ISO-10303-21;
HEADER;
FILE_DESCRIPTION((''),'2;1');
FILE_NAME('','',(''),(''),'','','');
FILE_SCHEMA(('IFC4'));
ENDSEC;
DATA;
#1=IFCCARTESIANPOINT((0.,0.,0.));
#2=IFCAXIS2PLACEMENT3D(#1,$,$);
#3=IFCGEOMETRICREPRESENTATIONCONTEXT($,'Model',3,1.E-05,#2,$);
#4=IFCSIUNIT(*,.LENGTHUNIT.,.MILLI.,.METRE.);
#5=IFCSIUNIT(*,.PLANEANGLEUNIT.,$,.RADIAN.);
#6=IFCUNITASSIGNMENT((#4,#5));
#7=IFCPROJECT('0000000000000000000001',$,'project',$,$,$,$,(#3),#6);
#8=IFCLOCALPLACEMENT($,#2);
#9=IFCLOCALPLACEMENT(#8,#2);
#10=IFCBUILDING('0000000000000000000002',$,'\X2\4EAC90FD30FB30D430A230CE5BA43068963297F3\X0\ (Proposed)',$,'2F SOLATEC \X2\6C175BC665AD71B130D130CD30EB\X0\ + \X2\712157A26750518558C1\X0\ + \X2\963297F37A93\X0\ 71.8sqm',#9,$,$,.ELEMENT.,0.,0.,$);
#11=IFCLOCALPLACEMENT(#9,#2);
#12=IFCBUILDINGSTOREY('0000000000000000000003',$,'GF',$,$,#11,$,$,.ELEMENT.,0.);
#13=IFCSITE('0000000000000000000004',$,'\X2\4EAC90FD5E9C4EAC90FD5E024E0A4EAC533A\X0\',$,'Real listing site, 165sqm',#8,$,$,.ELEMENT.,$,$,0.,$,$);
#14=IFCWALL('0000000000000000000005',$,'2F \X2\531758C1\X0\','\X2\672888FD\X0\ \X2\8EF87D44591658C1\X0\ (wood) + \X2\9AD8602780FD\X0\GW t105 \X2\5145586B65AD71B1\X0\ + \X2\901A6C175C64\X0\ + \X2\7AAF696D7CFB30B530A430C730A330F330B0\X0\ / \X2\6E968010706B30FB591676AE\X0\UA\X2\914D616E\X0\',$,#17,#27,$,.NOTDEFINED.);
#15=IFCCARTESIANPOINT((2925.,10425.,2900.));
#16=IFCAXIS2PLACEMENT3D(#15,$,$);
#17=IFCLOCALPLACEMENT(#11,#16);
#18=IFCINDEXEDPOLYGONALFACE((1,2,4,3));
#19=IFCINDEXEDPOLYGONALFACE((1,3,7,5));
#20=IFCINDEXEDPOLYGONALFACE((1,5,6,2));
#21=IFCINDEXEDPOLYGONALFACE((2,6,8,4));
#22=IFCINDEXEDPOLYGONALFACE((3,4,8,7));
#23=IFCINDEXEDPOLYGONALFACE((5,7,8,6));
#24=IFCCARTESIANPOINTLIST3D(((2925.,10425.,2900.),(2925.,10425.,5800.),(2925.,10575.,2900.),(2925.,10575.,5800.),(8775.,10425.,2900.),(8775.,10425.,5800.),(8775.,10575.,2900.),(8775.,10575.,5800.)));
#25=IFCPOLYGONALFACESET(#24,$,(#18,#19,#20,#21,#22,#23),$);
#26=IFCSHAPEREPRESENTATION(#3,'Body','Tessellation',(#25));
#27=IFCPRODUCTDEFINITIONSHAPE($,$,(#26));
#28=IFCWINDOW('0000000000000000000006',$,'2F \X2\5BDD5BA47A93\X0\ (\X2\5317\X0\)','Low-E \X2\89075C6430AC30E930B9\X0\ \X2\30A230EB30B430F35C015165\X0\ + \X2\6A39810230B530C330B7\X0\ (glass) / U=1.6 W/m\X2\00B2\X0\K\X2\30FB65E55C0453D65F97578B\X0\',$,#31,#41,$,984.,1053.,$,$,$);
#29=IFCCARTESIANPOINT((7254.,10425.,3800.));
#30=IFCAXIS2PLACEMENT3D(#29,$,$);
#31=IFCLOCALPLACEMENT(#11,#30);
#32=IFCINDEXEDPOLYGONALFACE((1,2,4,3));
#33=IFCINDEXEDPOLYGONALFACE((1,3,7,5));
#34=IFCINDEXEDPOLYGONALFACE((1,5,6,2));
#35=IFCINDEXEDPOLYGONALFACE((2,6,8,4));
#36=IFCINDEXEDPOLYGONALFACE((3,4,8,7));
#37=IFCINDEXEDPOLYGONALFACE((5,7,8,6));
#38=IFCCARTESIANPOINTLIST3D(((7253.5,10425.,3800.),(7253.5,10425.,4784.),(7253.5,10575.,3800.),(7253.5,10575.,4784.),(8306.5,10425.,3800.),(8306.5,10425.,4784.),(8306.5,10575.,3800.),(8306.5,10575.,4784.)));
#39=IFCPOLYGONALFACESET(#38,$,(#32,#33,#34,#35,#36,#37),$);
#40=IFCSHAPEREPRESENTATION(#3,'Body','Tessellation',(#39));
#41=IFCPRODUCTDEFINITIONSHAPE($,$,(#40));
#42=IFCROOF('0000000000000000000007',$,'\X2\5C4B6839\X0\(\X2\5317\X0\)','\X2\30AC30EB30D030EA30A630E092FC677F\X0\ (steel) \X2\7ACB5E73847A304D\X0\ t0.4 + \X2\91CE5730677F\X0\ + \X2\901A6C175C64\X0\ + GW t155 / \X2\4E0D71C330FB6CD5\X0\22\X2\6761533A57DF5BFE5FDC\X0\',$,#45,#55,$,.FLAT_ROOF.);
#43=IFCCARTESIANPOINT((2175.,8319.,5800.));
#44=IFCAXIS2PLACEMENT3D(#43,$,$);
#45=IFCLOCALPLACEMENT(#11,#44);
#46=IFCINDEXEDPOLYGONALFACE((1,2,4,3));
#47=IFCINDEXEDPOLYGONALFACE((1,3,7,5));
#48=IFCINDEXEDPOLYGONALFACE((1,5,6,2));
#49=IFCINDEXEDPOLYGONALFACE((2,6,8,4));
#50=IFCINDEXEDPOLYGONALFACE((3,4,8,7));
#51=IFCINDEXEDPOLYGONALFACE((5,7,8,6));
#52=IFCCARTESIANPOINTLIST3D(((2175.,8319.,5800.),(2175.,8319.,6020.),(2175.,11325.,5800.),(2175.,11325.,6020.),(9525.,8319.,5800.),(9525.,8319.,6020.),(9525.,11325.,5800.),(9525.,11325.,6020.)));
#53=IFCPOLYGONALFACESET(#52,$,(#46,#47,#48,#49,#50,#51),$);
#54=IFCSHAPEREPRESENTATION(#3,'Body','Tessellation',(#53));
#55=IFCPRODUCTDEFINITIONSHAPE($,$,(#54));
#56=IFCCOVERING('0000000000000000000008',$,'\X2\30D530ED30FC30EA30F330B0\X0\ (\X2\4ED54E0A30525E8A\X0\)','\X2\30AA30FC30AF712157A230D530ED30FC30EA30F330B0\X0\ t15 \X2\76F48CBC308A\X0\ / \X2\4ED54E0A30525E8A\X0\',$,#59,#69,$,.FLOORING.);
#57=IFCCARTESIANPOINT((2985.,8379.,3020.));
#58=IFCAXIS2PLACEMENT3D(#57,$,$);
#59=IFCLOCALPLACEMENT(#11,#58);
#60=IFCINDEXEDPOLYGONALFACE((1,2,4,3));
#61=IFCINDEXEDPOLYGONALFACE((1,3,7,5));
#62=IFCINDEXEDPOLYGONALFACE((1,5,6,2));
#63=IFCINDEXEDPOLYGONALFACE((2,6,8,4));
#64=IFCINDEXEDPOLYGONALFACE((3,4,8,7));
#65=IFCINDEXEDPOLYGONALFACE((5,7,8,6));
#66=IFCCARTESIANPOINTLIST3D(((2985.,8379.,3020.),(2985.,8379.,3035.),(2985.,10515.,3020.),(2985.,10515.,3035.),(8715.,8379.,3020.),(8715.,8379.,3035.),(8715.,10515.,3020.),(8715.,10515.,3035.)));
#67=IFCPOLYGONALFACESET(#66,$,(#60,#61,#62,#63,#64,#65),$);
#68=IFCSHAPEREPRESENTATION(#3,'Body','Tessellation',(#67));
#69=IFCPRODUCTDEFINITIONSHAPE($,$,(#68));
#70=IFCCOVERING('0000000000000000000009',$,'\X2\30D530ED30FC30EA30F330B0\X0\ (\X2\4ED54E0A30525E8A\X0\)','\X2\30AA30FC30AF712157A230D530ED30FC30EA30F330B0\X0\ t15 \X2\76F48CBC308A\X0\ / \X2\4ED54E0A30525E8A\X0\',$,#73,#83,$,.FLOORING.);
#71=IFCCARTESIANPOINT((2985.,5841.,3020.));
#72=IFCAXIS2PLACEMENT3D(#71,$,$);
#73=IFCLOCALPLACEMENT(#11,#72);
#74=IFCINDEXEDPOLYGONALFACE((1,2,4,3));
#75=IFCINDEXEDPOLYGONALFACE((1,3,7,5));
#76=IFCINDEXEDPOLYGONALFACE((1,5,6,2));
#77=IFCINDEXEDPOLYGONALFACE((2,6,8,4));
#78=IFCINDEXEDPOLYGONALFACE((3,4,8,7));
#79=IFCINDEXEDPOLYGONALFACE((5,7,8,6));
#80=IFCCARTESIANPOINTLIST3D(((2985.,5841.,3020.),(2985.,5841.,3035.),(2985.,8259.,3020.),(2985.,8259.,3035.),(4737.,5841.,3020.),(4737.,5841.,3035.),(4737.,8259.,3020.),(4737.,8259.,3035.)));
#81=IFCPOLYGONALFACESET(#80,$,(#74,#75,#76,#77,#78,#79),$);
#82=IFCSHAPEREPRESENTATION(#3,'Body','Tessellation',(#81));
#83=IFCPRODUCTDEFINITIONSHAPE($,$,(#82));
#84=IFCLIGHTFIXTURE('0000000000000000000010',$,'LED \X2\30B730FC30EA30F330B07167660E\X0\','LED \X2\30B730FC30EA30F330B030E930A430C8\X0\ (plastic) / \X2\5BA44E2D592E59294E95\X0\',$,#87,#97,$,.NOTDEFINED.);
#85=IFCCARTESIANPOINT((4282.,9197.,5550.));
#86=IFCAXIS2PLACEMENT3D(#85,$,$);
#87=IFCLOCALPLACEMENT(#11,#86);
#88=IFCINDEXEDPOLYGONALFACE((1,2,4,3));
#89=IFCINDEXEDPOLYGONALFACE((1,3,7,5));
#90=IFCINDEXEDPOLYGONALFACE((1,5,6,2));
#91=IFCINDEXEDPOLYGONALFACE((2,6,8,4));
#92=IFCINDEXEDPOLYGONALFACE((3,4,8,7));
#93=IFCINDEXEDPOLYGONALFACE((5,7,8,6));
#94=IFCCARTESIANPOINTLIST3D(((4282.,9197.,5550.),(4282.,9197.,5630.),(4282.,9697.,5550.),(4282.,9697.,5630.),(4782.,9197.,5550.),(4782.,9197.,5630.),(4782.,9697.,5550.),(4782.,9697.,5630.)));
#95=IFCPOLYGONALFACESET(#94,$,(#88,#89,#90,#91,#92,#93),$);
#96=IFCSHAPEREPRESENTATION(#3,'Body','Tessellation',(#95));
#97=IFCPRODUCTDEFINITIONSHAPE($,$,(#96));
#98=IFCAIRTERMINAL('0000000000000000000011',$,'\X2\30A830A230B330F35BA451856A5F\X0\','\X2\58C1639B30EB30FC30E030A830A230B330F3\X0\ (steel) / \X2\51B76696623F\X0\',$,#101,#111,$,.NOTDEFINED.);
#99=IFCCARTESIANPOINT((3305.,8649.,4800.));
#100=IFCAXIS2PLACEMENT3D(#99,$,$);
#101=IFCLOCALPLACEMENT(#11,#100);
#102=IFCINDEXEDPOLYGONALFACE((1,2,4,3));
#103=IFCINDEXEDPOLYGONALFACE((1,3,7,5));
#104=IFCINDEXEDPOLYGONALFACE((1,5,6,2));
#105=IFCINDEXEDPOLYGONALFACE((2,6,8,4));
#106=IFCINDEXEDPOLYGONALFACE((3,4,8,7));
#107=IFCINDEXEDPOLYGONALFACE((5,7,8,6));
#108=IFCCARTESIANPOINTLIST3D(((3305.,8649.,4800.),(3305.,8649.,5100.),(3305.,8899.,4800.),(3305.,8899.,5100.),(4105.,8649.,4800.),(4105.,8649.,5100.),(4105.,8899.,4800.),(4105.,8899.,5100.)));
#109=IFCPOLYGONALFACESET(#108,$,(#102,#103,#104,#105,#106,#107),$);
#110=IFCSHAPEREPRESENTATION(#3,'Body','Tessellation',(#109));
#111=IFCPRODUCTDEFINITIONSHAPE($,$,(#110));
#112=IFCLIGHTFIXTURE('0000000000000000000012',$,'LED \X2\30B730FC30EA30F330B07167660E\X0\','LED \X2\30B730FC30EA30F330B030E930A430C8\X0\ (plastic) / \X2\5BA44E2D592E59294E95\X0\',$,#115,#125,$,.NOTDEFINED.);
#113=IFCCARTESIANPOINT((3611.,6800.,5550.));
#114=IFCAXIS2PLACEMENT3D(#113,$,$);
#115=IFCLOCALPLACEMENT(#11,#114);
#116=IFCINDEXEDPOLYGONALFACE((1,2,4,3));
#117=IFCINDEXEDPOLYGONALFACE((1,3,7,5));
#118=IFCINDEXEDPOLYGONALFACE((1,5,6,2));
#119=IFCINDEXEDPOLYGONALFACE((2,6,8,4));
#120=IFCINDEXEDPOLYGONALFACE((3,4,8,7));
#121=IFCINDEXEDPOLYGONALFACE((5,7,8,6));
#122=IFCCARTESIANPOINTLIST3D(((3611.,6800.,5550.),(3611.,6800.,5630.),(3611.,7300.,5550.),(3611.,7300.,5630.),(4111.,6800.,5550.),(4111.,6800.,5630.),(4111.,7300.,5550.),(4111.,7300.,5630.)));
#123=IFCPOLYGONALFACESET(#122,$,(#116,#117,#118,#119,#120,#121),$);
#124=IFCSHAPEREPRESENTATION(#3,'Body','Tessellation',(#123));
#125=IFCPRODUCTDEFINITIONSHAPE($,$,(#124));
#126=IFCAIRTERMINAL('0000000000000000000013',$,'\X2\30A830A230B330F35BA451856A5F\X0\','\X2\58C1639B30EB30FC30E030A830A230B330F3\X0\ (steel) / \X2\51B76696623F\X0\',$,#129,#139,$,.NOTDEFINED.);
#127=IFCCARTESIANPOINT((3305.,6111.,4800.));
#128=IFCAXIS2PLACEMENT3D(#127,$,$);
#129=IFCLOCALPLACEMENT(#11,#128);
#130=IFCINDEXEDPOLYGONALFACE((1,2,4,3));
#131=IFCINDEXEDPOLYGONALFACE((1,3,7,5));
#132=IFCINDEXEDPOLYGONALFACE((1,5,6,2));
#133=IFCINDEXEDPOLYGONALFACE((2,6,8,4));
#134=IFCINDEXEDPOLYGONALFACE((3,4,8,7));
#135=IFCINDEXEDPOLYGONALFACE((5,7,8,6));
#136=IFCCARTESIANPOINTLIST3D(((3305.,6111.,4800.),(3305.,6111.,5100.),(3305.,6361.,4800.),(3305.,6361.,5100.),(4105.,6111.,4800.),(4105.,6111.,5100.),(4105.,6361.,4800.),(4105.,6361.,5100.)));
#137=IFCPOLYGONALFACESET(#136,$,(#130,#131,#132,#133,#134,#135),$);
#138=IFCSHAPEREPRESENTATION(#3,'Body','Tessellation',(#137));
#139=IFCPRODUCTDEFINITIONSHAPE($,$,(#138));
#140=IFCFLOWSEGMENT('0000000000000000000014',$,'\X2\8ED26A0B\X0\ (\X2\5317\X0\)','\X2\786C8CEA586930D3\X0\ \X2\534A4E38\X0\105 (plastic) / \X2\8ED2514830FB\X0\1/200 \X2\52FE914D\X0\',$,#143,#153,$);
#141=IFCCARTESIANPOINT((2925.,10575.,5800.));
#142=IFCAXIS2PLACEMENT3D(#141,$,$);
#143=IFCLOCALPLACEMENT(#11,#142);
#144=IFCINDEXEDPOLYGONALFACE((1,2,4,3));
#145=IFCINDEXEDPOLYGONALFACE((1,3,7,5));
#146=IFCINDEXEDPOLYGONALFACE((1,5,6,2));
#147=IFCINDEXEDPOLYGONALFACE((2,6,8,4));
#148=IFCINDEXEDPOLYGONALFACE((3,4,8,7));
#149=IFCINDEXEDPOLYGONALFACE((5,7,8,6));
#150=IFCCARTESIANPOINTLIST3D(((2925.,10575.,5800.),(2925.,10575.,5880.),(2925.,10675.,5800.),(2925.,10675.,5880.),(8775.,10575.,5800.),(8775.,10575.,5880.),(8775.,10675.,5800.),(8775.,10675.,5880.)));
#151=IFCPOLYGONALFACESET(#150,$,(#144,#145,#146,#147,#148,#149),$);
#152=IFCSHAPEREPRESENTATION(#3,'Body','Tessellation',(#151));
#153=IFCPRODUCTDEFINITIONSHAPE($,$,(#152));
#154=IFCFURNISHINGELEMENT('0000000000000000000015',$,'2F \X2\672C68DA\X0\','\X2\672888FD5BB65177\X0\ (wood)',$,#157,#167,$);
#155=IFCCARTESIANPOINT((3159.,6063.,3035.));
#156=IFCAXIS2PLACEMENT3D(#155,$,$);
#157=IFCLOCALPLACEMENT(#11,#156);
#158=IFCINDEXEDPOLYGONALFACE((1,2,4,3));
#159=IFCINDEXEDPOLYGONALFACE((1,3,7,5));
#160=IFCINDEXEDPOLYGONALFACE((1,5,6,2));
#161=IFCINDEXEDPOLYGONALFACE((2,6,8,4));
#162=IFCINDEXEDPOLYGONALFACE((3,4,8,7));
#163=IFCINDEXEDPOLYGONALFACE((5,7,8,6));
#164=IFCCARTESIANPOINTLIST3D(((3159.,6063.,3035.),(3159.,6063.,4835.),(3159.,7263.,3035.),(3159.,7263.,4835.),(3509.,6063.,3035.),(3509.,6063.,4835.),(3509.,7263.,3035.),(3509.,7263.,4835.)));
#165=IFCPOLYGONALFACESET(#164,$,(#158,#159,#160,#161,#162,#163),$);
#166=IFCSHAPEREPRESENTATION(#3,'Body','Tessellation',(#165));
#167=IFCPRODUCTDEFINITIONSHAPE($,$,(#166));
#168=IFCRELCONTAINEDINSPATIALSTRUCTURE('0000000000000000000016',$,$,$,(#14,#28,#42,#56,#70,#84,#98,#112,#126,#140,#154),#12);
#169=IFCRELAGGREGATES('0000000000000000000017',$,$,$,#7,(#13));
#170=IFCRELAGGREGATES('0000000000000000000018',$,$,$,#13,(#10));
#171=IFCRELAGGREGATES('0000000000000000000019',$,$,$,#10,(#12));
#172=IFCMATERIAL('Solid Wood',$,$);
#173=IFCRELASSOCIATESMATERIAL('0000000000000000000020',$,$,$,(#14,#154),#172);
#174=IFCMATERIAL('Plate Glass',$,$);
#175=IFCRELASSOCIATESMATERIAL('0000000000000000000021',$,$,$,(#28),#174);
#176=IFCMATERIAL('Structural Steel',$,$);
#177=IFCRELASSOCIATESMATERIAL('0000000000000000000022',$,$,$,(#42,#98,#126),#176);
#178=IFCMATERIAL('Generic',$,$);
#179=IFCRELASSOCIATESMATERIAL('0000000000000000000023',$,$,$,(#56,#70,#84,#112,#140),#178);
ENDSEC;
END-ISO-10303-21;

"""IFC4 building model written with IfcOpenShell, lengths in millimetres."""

from ifc_helpers import new_model, si_unit, frame, frame_2d, origin, place, context, project, spatial, rectangle, extrude, material, element, fill, save


model = new_model("IFC4")

# Units and contexts
model_context = context("Model", 3, precision=1e-05, world=origin())
ifc_project = project(units=[si_unit("LENGTHUNIT", "METRE", prefix="MILLI"), si_unit("PLANEANGLEUNIT", "RADIAN")], contexts=[model_context])

# Site, building, storey
site_placement = place(None, origin())
site = spatial("IfcSite", under=ifc_project, at=site_placement, Name="京都府京都市上京区", ObjectType="Real listing site, 165sqm", CompositionType="ELEMENT", RefElevation=0.0)
building_placement = place(site_placement, origin())
building = spatial("IfcBuilding", under=site, at=building_placement, Name="京都・ピアノ室と防音 (Proposed)", ObjectType="2F SOLATEC 気密断熱パネル + 無垢材内壁 + 防音窓 71.8sqm", CompositionType="ELEMENT", ElevationOfRefHeight=0.0, ElevationOfTerrain=0.0)
storey_placement = place(building_placement, origin())
storey = spatial("IfcBuildingStorey", under=building, at=storey_placement, Name="GF", CompositionType="ELEMENT", Elevation=0.0)

# Shared definitions
ifc_material_1 = material(Name="Solid Wood")

# Wall, opening, window
wall_placement = place(storey_placement, frame((2925.0, 10425.0, 2900.0)))
wall = element("IfcWall", 1, at=wall_placement, inside=storey, material=ifc_material_1, Name="2F 北壁", Description="木製 軸組外壁 (wood) + 高性能GW t105 充填断熱 + 通気層 + 窯業系サイディング / 準耐火・外皮UA配慮", PredefinedType="NOTDEFINED", context=model_context, shape_type="SweptSolid", body=[
    extrude(rectangle(XDim=5850.0, YDim=150.0, at=frame_2d((2925.0, 75.0))), frame((2925.0, 10425.0, 2900.0)), (0.0, 0.0, 1.0), 2900.0),
])
opening_placement = place(storey_placement, frame((7254.0, 10425.0, 3800.0)))
opening = element("IfcOpeningElement", 2, at=opening_placement, cuts=wall, PredefinedType="NOTDEFINED", context=model_context, shape_type="SweptSolid", body=[
    extrude(rectangle(XDim=1053.0, YDim=150.0, at=frame_2d((526.0, 75.0))), frame((7254.0, 10425.0, 3800.0)), (0.0, 0.0, 1.0), 984.0),
])
ifc_material_2 = material(Name="Plate Glass")
window_placement = place(storey_placement, frame((7254.0, 10425.0, 3800.0)))
window = element("IfcWindow", 3, at=window_placement, inside=storey, material=ifc_material_2, Name="2F 寝室窓 (北)", Description="Low-E 複層ガラス アルゴン封入 + 樹脂サッシ (glass) / U=1.6 W/m²K・日射取得型", OverallHeight=984.0, OverallWidth=1053.0, context=model_context, shape_type="SweptSolid", body=[
    extrude(rectangle(XDim=1053.0, YDim=150.0, at=frame_2d((526.0, 75.0))), frame((7254.0, 10425.0, 3800.0)), (0.0, 0.0, 1.0), 984.0),
])
fill(opening, window)

# Roof
ifc_material_3 = material(Name="Structural Steel")
for number, where, name in (
    (4, (2175.0, 8319.0, 5800.0), "屋根(北)"),
):
    element("IfcRoof", number, at=place(storey_placement, frame(where)), inside=storey, material=ifc_material_3, Name=name, Description="ガルバリウム鋼板 (steel) 立平葺き t0.4 + 野地板 + 通気層 + GW t155 / 不燃・法22条区域対応", PredefinedType="FLAT_ROOF", context=model_context, shape_type="SweptSolid", body=[
        extrude(rectangle(XDim=7350.0, YDim=3006.0, at=frame_2d((3675.0, 1503.0))), frame((2175.0, 8319.0, 5800.0)), (0.0, 0.0, 1.0), 220.0),
    ])

# Coverings
ifc_material_4 = material(Name="Generic")
covering_1_placement = place(storey_placement, frame((2985.0, 8379.0, 3020.0)))
element("IfcCovering", 5, at=covering_1_placement, inside=storey, material=ifc_material_4, Name="フローリング (仕上げ床)", Description="オーク無垢フローリング t15 直貼り / 仕上げ床", PredefinedType="FLOORING", context=model_context, shape_type="SweptSolid", body=[
    extrude(rectangle(XDim=5730.0, YDim=2136.0, at=frame_2d((2865.0, 1068.0))), frame((2985.0, 8379.0, 3020.0)), (0.0, 0.0, 1.0), 15.0),
])
covering_2_placement = place(storey_placement, frame((2985.0, 5841.0, 3020.0)))
element("IfcCovering", 6, at=covering_2_placement, inside=storey, material=ifc_material_4, Name="フローリング (仕上げ床)", Description="オーク無垢フローリング t15 直貼り / 仕上げ床", PredefinedType="FLOORING", context=model_context, shape_type="SweptSolid", body=[
    extrude(rectangle(XDim=1752.0, YDim=2418.0, at=frame_2d((876.0, 1209.0))), frame((2985.0, 5841.0, 3020.0)), (0.0, 0.0, 1.0), 15.0),
])

# Light fixture
light_fixture_1_placement = place(storey_placement, frame((4282.0, 9197.0, 5550.0)))
element("IfcLightFixture", 7, at=light_fixture_1_placement, inside=storey, material=ifc_material_4, Name="LED シーリング照明", Description="LED シーリングライト (plastic) / 室中央天井", PredefinedType="NOTDEFINED", context=model_context, shape_type="SweptSolid", body=[
    extrude(rectangle(XDim=500.0, YDim=500.0, at=frame_2d((250.0, 250.0))), frame((4282.0, 9197.0, 5550.0)), (0.0, 0.0, 1.0), 80.0),
])

# Air terminal
air_terminal_1_placement = place(storey_placement, frame((3305.0, 8649.0, 4800.0)))
element("IfcAirTerminal", 8, at=air_terminal_1_placement, inside=storey, material=ifc_material_3, Name="エアコン室内機", Description="壁掛ルームエアコン (steel) / 冷暖房", PredefinedType="NOTDEFINED", context=model_context, shape_type="SweptSolid", body=[
    extrude(rectangle(XDim=800.0, YDim=250.0, at=frame_2d((400.0, 125.0))), frame((3305.0, 8649.0, 4800.0)), (0.0, 0.0, 1.0), 300.0),
])

# Light fixture
light_fixture_2_placement = place(storey_placement, frame((3611.0, 6800.0, 5550.0)))
element("IfcLightFixture", 9, at=light_fixture_2_placement, inside=storey, material=ifc_material_4, Name="LED シーリング照明", Description="LED シーリングライト (plastic) / 室中央天井", PredefinedType="NOTDEFINED", context=model_context, shape_type="SweptSolid", body=[
    extrude(rectangle(XDim=500.0, YDim=500.0, at=frame_2d((250.0, 250.0))), frame((3611.0, 6800.0, 5550.0)), (0.0, 0.0, 1.0), 80.0),
])

# Air terminal
air_terminal_2_placement = place(storey_placement, frame((3305.0, 6111.0, 4800.0)))
element("IfcAirTerminal", 10, at=air_terminal_2_placement, inside=storey, material=ifc_material_3, Name="エアコン室内機", Description="壁掛ルームエアコン (steel) / 冷暖房", PredefinedType="NOTDEFINED", context=model_context, shape_type="SweptSolid", body=[
    extrude(rectangle(XDim=800.0, YDim=250.0, at=frame_2d((400.0, 125.0))), frame((3305.0, 6111.0, 4800.0)), (0.0, 0.0, 1.0), 300.0),
])

# Flow segment
flow_segment_placement = place(storey_placement, frame((2925.0, 10575.0, 5800.0)))
element("IfcFlowSegment", 11, at=flow_segment_placement, inside=storey, material=ifc_material_4, Name="軒樋 (北)", Description="硬質塩ビ 半丸105 (plastic) / 軒先・1/200 勾配", context=model_context, shape_type="SweptSolid", body=[
    extrude(rectangle(XDim=5850.0, YDim=100.0, at=frame_2d((2925.0, 50.0))), frame((2925.0, 10575.0, 5800.0)), (0.0, 0.0, 1.0), 80.0),
])

# Furnishing element
furnishing_placement = place(storey_placement, frame((3159.0, 6063.0, 3035.0)))
element("IfcFurnishingElement", 12, at=furnishing_placement, inside=storey, material=ifc_material_1, Name="2F 本棚", Description="木製家具 (wood)", context=model_context, shape_type="SweptSolid", body=[
    extrude(rectangle(XDim=350.0, YDim=1200.0, at=frame_2d((175.0, 600.0))), frame((3159.0, 6063.0, 3035.0)), (0.0, 0.0, 1.0), 1800.0),
])

save(model, "model.ifc")
